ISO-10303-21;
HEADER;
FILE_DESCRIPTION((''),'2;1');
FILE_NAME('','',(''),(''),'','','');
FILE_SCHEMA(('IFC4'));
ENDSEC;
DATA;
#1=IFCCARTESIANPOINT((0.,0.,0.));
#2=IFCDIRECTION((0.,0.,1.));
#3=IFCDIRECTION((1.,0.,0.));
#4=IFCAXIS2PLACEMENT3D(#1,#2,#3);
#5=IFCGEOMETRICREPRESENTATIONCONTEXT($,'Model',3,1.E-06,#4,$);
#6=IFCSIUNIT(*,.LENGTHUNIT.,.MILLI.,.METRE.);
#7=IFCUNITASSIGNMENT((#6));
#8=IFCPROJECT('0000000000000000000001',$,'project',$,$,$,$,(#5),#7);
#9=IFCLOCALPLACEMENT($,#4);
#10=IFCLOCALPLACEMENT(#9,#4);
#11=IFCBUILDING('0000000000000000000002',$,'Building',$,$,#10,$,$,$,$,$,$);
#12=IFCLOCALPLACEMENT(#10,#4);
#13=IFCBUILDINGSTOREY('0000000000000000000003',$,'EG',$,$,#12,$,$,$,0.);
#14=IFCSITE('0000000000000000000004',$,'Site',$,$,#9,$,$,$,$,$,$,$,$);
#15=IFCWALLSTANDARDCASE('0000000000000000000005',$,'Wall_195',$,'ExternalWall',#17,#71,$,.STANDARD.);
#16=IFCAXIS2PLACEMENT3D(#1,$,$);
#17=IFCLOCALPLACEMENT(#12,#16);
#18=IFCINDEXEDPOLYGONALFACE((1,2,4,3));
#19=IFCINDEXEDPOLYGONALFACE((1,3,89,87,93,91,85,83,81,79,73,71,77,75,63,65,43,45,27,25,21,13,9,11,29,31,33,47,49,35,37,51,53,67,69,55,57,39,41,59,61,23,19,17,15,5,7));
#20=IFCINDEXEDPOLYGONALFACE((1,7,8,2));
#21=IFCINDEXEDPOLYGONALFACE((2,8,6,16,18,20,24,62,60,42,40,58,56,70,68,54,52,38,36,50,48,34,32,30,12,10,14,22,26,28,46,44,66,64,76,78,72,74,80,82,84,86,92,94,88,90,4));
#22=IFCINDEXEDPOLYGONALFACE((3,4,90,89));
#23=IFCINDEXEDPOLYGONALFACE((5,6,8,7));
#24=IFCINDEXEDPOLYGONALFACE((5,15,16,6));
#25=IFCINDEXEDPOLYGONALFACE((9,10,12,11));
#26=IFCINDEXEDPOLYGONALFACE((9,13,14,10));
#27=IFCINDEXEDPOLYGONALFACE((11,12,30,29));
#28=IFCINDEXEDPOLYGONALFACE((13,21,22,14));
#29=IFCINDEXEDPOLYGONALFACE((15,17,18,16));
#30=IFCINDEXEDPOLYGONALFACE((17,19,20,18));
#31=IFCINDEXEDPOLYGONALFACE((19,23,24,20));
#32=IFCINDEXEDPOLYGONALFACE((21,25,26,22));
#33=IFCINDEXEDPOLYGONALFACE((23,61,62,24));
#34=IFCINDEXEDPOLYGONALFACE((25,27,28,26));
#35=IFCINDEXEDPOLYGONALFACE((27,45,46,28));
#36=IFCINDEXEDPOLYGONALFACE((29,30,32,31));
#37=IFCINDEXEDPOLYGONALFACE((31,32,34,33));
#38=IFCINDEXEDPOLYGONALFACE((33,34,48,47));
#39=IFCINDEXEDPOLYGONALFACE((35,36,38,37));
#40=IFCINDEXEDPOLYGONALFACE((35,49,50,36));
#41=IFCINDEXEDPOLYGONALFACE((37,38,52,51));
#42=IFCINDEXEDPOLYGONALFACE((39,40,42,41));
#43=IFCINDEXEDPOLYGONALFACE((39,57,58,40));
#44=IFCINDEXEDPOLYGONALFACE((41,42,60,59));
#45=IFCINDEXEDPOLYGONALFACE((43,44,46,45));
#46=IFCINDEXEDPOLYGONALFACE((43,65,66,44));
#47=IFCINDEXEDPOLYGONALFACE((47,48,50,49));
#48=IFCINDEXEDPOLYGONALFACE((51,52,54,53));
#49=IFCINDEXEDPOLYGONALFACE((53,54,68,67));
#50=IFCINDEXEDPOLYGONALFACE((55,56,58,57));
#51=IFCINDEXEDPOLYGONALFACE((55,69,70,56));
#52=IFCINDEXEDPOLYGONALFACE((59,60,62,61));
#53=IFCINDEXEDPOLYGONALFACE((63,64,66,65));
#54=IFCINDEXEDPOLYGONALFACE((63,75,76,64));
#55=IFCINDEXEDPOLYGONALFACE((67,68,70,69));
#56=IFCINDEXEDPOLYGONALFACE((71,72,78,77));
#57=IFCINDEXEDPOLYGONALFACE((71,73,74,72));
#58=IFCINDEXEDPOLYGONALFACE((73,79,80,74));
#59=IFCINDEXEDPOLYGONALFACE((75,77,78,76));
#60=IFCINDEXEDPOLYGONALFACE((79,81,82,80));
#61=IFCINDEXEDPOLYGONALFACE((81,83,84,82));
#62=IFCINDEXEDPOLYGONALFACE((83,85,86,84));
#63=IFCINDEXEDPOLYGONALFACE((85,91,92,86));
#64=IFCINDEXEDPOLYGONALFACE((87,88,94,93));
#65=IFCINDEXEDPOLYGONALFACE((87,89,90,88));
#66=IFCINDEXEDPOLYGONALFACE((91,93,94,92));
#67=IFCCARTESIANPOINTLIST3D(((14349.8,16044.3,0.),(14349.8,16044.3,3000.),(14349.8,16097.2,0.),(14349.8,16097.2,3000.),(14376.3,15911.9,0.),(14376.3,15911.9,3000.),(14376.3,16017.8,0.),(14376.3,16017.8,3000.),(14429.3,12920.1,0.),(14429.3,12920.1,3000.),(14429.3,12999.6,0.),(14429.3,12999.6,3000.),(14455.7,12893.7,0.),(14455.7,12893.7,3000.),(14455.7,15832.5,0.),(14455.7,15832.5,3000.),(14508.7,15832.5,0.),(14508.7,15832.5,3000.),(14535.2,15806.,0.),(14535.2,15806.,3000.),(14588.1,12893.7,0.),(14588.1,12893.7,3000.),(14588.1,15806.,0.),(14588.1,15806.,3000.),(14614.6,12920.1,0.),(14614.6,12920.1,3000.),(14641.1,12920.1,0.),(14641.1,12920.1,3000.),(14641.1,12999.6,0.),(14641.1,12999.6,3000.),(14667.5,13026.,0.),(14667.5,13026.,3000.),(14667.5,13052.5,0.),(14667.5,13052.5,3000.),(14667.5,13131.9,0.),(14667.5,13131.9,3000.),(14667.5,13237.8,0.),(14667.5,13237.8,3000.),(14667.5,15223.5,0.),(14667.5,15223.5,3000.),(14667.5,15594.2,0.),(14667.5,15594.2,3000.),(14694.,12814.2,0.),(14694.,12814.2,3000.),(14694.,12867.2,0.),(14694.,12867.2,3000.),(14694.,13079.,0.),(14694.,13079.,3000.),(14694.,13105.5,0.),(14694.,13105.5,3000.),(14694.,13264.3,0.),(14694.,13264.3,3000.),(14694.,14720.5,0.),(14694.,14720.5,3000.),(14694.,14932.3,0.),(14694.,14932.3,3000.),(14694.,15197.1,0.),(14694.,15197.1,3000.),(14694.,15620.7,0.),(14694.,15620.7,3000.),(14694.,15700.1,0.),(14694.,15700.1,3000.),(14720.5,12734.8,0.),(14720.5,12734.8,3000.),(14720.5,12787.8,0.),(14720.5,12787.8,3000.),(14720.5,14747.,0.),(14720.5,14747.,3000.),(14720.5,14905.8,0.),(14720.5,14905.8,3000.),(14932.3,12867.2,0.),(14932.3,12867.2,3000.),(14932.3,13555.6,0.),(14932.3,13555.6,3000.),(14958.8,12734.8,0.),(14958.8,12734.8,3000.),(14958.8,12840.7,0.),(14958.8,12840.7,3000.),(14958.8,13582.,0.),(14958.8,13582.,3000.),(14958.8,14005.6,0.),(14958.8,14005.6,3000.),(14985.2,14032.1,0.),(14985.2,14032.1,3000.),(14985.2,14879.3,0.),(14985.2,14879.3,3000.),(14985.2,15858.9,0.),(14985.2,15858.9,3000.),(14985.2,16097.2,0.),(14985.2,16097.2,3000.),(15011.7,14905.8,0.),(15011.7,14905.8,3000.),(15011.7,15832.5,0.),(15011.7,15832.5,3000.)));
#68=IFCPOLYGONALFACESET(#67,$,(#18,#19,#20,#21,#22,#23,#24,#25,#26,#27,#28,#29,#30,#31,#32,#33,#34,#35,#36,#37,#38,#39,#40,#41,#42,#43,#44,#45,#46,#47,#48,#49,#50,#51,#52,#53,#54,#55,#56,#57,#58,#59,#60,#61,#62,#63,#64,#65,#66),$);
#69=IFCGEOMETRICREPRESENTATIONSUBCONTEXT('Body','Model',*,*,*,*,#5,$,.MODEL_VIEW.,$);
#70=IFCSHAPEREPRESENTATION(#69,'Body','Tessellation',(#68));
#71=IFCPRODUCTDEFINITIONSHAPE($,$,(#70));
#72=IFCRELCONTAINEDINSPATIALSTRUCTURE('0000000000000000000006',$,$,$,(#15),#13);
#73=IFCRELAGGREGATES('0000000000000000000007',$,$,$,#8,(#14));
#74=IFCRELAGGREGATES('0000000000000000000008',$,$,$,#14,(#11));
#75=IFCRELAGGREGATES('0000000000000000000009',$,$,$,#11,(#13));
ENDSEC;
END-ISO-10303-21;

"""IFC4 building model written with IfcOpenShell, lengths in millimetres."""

from ifc_helpers import new_model, si_unit, origin_with_axes, place, context, subcontext, project, spatial, polyline, outline, extrude, element, save


model = new_model("IFC4")

# Units and contexts
model_context = context("Model", 3, precision=1e-06, world=origin_with_axes())
body_context = subcontext(model_context, "Body", "Model", "MODEL_VIEW")
ifc_project = project(units=[si_unit("LENGTHUNIT", "METRE", prefix="MILLI")], contexts=[model_context])

# Site, building, storey
site_placement = place(None, origin_with_axes())
site = spatial("IfcSite", under=ifc_project, at=site_placement, Name="Site")
building_placement = place(site_placement, origin_with_axes())
building = spatial("IfcBuilding", under=site, at=building_placement, Name="Building")
storey_placement = place(building_placement, origin_with_axes())
storey = spatial("IfcBuildingStorey", under=building, at=storey_placement, Name="EG", Elevation=0.0)

# Wall
wall_1_placement = place(storey_placement, origin_with_axes())
element("IfcWallStandardCase", 1, at=wall_1_placement, inside=storey, Name="Wall_195", ObjectType="ExternalWall", PredefinedType="STANDARD", context=body_context, shape_type="SweptSolid", body=[
    extrude(outline(polyline([(14720.5, 12734.8, 0.0), (14720.5, 12787.8, 0.0), (14694.0, 12814.2, 0.0), (14694.0, 12867.2, 0.0), (14641.1, 12920.1, 0.0), (14614.6, 12920.1, 0.0), (14588.1, 12893.7, 0.0), (14455.7, 12893.7, 0.0), (14429.3, 12920.1, 0.0), (14429.3, 12999.6, 0.0), (14641.1, 12999.6, 0.0), (14667.5, 13026.0, 0.0), (14667.5, 13052.5, 0.0), (14694.0, 13079.0, 0.0), (14694.0, 13105.5, 0.0), (14667.5, 13131.9, 0.0), (14667.5, 13237.8, 0.0), (14694.0, 13264.3, 0.0), (14694.0, 14720.5, 0.0), (14720.5, 14747.0, 0.0), (14720.5, 14905.8, 0.0), (14694.0, 14932.3, 0.0), (14694.0, 15197.1, 0.0), (14667.5, 15223.5, 0.0), (14667.5, 15594.2, 0.0), (14694.0, 15620.7, 0.0), (14694.0, 15700.1, 0.0), (14588.1, 15806.0, 0.0), (14535.2, 15806.0, 0.0), (14508.7, 15832.5, 0.0), (14455.7, 15832.5, 0.0), (14376.3, 15911.9, 0.0), (14376.3, 16017.8, 0.0), (14349.8, 16044.3, 0.0), (14349.8, 16097.2, 0.0), (14985.2, 16097.2, 0.0), (14985.2, 15858.9, 0.0), (15011.7, 15832.5, 0.0), (15011.7, 14905.8, 0.0), (14985.2, 14879.3, 0.0), (14985.2, 14032.1, 0.0), (14958.8, 14005.6, 0.0), (14958.8, 13582.0, 0.0), (14932.3, 13555.6, 0.0), (14932.3, 12867.2, 0.0), (14958.8, 12840.7, 0.0), (14958.8, 12734.8, 0.0), (14720.5, 12734.8, 0.0)])), origin_with_axes(), (0.0, 0.0, 1.0), 3000.0),
])

save(model, "model.ifc")
